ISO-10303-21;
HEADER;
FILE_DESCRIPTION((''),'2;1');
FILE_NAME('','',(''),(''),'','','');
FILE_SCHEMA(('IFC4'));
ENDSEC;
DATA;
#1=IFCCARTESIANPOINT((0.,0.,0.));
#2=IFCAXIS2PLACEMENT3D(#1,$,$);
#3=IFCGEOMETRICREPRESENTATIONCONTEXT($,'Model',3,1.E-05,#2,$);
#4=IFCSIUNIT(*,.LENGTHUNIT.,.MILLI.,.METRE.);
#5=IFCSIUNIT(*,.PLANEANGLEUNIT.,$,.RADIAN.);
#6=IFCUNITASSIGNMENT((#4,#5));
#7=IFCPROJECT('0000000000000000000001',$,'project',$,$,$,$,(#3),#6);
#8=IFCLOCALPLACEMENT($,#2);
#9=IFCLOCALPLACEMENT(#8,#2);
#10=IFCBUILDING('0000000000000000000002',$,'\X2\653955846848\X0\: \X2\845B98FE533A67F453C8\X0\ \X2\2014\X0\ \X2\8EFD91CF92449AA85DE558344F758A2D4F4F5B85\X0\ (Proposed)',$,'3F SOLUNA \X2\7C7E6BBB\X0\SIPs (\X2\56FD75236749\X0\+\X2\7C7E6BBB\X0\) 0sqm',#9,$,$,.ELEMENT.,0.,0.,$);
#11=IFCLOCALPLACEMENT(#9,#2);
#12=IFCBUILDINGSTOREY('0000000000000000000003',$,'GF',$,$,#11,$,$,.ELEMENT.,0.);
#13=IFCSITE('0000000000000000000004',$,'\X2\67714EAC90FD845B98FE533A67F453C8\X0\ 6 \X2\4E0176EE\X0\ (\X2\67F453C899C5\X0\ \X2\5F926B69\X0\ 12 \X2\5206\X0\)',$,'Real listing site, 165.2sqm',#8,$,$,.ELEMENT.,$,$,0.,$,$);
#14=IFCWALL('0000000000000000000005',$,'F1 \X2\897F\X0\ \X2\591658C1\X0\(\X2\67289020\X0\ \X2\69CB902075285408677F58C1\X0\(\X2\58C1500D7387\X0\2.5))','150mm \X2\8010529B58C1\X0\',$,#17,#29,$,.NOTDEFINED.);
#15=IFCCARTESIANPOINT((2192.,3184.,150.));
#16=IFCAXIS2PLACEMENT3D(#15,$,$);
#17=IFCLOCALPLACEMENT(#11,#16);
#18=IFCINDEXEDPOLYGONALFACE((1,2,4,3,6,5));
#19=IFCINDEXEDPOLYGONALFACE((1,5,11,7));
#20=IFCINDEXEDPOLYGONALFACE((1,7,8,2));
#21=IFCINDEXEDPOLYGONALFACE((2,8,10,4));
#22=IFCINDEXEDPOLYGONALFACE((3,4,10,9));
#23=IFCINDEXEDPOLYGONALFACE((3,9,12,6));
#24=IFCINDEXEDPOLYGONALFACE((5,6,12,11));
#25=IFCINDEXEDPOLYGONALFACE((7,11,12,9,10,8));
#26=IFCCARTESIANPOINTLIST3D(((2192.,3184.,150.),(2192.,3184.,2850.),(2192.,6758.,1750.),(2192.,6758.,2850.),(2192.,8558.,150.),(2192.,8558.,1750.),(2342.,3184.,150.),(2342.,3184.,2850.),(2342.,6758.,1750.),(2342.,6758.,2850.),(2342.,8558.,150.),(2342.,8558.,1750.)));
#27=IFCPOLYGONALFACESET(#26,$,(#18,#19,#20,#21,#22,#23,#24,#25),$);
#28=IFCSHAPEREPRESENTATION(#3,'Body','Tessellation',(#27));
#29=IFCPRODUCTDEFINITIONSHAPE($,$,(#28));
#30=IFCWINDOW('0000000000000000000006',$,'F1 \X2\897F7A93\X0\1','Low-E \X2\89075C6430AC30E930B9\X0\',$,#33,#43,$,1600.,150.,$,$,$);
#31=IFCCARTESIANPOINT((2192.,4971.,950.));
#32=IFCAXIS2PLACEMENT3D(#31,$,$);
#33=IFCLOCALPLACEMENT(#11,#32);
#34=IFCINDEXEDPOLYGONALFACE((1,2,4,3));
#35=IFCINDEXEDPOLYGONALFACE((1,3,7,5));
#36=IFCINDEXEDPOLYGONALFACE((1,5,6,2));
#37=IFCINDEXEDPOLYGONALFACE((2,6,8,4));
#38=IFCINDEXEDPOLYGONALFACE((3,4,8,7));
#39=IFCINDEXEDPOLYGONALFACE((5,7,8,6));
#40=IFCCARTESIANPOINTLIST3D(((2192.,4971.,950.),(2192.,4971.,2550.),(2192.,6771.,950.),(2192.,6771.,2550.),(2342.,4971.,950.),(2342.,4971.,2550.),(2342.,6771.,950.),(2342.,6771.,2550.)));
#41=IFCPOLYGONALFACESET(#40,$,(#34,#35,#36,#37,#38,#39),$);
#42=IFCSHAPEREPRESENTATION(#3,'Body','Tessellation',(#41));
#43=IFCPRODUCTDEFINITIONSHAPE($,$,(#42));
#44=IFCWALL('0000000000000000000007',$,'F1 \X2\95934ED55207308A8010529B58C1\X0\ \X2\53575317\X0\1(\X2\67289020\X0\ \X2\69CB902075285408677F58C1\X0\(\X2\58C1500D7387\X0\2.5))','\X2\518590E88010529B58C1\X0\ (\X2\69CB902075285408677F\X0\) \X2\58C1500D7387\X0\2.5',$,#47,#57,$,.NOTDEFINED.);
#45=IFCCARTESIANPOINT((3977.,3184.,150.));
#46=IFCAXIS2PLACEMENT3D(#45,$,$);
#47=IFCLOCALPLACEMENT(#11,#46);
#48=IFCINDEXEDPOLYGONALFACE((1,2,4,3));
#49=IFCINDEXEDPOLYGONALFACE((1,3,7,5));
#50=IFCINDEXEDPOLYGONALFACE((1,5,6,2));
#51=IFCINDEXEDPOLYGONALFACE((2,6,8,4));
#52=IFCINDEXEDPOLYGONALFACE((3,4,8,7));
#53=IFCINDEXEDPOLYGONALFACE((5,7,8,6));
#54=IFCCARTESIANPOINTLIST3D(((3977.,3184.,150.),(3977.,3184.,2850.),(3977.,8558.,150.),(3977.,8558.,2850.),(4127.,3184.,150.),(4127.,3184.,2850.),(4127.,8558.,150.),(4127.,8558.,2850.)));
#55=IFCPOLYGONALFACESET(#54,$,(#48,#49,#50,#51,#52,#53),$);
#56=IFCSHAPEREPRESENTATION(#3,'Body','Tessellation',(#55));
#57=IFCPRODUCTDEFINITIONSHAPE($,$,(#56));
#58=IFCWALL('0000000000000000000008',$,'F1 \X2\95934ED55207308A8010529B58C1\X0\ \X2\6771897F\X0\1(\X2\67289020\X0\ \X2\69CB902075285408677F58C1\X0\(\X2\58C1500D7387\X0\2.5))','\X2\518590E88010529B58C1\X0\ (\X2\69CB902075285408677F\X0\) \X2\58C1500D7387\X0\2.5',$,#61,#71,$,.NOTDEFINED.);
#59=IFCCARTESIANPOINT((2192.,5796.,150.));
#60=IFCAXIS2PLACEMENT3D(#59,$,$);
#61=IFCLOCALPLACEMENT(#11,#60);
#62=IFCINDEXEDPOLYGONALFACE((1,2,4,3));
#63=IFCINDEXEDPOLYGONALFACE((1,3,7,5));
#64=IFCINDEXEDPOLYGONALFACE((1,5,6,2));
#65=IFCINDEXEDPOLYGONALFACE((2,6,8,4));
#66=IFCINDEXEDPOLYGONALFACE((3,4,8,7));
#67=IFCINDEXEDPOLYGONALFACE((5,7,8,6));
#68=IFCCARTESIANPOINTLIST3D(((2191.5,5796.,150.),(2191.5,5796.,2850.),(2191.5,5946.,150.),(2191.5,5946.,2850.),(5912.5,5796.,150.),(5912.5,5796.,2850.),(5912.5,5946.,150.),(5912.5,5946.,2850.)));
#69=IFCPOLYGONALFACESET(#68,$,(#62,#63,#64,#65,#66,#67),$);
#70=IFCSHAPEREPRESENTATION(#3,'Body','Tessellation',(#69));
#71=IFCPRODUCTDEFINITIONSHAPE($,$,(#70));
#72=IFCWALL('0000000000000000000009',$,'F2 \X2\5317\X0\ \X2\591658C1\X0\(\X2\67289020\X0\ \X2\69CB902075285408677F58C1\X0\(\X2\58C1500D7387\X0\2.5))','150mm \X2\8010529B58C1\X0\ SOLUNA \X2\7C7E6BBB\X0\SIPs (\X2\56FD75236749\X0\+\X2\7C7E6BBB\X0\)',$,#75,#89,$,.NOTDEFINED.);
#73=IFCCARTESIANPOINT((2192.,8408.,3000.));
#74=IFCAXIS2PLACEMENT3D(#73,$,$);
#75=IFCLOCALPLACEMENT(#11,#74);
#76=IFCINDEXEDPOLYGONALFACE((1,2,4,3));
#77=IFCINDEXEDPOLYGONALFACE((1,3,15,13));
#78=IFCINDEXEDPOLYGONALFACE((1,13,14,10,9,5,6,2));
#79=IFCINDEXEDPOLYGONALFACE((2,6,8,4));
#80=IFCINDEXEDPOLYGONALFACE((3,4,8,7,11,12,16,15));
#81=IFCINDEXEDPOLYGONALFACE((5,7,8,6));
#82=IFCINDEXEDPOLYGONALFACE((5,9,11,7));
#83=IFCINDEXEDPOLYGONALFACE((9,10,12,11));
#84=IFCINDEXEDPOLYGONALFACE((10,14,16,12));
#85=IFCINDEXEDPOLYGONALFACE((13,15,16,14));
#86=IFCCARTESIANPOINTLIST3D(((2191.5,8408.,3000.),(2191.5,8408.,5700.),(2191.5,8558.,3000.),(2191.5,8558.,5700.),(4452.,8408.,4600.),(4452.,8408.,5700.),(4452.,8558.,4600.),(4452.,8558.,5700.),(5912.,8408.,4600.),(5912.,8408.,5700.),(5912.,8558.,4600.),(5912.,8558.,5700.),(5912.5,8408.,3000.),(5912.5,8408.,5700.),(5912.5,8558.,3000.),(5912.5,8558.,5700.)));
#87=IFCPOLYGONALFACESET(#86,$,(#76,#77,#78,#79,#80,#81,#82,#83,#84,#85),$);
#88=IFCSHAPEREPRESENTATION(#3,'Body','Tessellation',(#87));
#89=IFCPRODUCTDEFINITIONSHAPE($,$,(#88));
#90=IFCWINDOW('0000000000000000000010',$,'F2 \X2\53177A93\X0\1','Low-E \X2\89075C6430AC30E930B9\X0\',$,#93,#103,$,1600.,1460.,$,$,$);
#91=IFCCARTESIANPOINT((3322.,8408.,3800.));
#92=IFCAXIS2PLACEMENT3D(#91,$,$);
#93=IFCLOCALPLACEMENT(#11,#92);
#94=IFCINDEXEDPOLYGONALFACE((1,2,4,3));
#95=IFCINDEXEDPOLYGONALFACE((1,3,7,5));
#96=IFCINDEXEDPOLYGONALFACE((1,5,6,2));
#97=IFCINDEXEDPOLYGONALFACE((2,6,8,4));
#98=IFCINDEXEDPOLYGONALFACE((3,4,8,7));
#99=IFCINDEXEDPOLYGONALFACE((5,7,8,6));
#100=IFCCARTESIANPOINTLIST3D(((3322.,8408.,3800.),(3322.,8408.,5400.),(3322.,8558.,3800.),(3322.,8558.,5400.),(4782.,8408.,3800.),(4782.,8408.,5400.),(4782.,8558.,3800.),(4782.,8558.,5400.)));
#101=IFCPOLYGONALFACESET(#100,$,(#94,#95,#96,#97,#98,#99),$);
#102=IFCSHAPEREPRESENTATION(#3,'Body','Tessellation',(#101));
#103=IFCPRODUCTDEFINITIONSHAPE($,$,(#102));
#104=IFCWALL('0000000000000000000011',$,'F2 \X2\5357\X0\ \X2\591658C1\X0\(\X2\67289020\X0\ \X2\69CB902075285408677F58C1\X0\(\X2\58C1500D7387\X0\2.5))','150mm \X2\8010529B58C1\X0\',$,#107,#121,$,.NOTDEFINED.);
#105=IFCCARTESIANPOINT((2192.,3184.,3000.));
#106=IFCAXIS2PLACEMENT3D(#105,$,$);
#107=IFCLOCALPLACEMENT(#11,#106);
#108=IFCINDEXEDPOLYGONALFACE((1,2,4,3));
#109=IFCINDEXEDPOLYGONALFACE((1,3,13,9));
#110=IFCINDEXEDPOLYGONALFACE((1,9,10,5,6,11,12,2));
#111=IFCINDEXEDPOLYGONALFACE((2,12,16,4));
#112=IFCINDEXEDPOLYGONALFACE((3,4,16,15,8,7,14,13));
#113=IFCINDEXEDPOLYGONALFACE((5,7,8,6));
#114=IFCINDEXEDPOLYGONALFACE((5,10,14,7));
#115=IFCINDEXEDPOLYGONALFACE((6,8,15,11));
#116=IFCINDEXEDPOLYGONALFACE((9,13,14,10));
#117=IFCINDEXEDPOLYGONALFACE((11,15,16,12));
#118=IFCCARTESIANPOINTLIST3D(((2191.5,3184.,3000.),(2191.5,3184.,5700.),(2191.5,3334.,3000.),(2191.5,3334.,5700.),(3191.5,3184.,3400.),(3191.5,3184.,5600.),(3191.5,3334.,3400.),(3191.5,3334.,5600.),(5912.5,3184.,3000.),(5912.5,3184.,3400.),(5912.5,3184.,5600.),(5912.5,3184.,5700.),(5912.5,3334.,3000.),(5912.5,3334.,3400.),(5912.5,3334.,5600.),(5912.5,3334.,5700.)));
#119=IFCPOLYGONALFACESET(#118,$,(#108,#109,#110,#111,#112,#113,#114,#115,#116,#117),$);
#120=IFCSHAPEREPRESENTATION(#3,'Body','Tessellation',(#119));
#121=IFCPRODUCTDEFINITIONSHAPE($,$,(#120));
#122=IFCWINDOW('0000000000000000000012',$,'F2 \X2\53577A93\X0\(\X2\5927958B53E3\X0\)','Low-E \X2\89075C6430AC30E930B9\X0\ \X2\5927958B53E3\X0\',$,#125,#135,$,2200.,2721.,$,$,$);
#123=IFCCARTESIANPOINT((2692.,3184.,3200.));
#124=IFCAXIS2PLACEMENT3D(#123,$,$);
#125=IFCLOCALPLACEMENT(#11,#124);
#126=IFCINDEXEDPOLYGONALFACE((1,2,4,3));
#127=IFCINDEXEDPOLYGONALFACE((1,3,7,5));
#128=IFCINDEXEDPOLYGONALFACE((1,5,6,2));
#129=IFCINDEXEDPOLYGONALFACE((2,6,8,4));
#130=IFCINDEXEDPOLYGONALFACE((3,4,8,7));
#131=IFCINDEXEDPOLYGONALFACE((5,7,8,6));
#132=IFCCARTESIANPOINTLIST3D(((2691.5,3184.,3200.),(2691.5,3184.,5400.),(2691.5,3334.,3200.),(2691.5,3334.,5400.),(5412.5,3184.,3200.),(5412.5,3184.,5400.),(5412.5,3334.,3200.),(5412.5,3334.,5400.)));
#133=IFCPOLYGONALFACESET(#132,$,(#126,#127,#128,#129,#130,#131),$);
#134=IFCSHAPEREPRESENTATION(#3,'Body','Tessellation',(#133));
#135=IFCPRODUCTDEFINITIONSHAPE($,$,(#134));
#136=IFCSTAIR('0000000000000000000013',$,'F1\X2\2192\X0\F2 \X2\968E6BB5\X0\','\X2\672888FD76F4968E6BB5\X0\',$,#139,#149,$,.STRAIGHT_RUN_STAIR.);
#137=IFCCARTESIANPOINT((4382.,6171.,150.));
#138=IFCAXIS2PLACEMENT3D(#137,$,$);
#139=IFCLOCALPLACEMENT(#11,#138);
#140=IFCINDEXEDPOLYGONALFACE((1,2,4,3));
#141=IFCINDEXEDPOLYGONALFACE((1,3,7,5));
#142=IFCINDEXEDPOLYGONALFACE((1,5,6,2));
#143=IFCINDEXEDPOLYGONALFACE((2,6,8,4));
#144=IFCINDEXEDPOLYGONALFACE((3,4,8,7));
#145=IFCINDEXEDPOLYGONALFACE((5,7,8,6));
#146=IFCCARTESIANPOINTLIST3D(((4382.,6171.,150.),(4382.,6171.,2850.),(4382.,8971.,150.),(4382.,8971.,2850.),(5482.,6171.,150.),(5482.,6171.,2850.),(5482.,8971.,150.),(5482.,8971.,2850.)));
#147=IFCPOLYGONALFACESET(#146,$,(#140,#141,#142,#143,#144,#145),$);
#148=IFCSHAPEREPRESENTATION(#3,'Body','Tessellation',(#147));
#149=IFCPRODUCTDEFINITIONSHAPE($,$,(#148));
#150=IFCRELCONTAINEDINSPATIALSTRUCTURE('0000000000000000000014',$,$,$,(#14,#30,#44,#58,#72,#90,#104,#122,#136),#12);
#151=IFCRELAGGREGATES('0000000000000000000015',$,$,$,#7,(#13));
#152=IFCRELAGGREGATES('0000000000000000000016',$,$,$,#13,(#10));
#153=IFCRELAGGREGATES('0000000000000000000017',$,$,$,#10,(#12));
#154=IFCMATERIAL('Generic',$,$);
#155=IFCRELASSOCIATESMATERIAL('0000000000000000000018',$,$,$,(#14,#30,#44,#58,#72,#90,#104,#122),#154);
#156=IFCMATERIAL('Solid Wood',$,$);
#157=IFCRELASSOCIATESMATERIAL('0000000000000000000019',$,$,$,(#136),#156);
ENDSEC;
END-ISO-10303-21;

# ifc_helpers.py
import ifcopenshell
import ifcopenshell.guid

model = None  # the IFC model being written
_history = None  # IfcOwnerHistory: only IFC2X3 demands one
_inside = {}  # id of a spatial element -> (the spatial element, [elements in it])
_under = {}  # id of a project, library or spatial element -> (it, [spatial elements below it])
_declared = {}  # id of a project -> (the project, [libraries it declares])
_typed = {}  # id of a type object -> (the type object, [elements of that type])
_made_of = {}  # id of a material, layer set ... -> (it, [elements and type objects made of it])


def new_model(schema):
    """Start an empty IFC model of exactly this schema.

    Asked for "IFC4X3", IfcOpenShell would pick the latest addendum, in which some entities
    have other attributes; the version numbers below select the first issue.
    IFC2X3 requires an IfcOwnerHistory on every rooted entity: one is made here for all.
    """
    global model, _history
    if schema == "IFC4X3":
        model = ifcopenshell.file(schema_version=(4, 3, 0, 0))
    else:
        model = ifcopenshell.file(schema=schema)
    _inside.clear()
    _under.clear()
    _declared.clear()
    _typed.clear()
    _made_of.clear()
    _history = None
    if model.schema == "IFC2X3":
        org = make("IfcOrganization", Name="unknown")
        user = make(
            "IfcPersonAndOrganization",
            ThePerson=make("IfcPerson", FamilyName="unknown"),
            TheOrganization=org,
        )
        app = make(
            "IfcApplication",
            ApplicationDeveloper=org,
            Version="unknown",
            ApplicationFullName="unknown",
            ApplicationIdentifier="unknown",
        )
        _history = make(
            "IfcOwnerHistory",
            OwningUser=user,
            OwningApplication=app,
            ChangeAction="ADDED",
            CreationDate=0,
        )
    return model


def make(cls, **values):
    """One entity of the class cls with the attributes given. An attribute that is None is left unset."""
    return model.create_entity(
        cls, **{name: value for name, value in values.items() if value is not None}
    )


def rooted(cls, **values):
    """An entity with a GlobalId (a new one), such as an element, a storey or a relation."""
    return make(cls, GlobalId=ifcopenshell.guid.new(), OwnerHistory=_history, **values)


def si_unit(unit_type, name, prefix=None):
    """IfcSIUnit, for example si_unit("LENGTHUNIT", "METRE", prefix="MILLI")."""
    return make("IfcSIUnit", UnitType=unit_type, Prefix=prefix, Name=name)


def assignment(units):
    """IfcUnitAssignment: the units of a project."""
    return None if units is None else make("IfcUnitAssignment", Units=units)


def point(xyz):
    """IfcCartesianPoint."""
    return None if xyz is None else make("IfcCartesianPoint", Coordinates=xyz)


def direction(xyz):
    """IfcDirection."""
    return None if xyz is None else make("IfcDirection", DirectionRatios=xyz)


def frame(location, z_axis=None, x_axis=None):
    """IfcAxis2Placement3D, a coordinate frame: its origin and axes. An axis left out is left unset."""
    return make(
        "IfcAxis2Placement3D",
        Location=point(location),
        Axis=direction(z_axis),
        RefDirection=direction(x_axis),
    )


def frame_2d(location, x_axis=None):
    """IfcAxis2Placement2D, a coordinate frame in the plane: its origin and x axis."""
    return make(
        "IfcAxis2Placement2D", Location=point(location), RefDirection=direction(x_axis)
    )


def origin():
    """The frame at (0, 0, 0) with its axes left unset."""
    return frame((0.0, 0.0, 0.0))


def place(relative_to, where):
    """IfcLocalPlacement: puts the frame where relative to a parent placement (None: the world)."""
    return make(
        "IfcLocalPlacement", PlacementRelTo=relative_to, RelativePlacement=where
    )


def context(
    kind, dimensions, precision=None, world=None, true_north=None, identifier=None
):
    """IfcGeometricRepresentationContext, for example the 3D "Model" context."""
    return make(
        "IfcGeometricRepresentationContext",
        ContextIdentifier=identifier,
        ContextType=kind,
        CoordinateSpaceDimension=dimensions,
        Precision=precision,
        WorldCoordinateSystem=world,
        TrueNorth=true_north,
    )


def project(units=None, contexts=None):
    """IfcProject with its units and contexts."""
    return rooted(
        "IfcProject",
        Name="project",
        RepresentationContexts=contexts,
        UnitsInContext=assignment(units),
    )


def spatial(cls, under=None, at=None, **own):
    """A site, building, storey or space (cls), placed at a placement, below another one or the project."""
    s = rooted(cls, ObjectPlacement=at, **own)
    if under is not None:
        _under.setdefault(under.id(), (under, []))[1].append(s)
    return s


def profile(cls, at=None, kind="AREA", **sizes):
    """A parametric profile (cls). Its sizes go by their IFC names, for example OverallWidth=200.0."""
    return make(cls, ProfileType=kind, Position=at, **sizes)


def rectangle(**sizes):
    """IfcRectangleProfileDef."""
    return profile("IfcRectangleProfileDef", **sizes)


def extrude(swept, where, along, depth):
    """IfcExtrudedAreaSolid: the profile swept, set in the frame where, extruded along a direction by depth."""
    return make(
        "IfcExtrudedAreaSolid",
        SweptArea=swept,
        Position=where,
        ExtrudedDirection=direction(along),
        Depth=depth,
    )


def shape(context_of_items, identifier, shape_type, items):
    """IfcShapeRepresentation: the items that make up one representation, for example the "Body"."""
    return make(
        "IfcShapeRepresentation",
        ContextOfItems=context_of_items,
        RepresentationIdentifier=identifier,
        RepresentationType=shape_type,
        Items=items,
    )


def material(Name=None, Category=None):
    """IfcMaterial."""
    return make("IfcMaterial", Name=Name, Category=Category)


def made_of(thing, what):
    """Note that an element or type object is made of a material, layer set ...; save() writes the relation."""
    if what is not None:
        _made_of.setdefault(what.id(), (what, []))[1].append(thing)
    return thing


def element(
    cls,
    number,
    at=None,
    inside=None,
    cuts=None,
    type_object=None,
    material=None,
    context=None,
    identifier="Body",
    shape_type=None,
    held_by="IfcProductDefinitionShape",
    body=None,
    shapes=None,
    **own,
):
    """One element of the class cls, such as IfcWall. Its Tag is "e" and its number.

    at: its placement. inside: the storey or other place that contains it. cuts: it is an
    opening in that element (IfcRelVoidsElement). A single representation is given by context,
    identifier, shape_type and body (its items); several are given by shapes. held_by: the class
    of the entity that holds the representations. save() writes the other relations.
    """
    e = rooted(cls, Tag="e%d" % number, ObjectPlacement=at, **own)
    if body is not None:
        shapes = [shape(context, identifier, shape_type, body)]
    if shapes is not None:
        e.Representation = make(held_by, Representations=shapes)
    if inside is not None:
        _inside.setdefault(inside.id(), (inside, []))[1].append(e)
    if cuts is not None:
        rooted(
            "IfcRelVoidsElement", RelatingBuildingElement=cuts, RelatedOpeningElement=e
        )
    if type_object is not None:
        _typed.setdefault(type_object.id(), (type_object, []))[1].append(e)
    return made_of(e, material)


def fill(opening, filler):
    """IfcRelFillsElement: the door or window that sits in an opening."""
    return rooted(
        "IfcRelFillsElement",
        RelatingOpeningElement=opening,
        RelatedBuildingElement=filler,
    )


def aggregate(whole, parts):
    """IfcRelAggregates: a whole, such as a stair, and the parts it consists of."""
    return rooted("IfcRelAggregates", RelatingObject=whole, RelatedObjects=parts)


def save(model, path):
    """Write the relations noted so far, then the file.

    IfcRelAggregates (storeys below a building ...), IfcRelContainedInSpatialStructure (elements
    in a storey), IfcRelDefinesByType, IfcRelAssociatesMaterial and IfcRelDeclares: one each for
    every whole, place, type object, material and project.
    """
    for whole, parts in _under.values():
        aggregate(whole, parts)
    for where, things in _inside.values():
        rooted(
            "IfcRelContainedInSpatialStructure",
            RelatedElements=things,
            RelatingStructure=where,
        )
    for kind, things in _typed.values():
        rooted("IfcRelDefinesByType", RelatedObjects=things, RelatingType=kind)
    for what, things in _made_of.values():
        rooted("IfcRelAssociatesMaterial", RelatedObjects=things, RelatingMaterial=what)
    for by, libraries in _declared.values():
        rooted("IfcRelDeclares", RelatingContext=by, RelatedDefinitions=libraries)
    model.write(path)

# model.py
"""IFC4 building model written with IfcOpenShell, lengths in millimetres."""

from ifc_helpers import new_model, si_unit, frame, frame_2d, origin, place, context, project, spatial, rectangle, extrude, material, element, fill, save


model = new_model("IFC4")

# Units and contexts
model_context = context("Model", 3, precision=1e-05, world=origin())
ifc_project = project(units=[si_unit("LENGTHUNIT", "METRE", prefix="MILLI"), si_unit("PLANEANGLEUNIT", "RADIAN")], contexts=[model_context])

# Site, building, storey
site_placement = place(None, origin())
site = spatial("IfcSite", under=ifc_project, at=site_placement, Name="東京都葛飾区柴又 6 丁目 (柴又駅 徒歩 12 分)", ObjectType="Real listing site, 165.2sqm", CompositionType="ELEMENT", RefElevation=0.0)
building_placement = place(site_placement, origin())
building = spatial("IfcBuilding", under=site, at=building_placement, Name="改善案: 葛飾区柴又 — 軽量鉄骨工場併設住宅 (Proposed)", ObjectType="3F SOLUNA 籾殻SIPs (国産杉+籾殻) 0sqm", CompositionType="ELEMENT", ElevationOfRefHeight=0.0, ElevationOfTerrain=0.0)
storey_placement = place(building_placement, origin())
storey = spatial("IfcBuildingStorey", under=building, at=storey_placement, Name="GF", CompositionType="ELEMENT", Elevation=0.0)

# Shared definitions
ifc_material_1 = material(Name="Generic")

# Shared definitions
ifc_material_2 = material(Name="Solid Wood")

# Wall, opening, window
wall_1_placement = place(storey_placement, frame((2192.0, 3184.0, 150.0)))
wall_1 = element("IfcWall", 1, at=wall_1_placement, inside=storey, material=ifc_material_1, Name="F1 西 外壁(木造 構造用合板壁(壁倍率2.5))", Description="150mm 耐力壁", PredefinedType="NOTDEFINED", context=model_context, shape_type="SweptSolid", body=[
    extrude(rectangle(XDim=150.0, YDim=5374.0, at=frame_2d((75.0, 2687.0))), frame((2192.0, 3184.0, 150.0)), (0.0, 0.0, 1.0), 2700.0),
])
opening_1_placement = place(storey_placement, frame((2192.0, 4971.0, 950.0)))
opening_1 = element("IfcOpeningElement", 2, at=opening_1_placement, cuts=wall_1, PredefinedType="NOTDEFINED", context=model_context, shape_type="SweptSolid", body=[
    extrude(rectangle(XDim=150.0, YDim=1800.0, at=frame_2d((75.0, 900.0))), frame((2192.0, 4971.0, 950.0)), (0.0, 0.0, 1.0), 1600.0),
])
window_1_placement = place(storey_placement, frame((2192.0, 4971.0, 950.0)))
window_1 = element("IfcWindow", 3, at=window_1_placement, inside=storey, material=ifc_material_1, Name="F1 西窓1", Description="Low-E 複層ガラス", OverallHeight=1600.0, OverallWidth=150.0, context=model_context, shape_type="SweptSolid", body=[
    extrude(rectangle(XDim=150.0, YDim=1800.0, at=frame_2d((75.0, 900.0))), frame((2192.0, 4971.0, 950.0)), (0.0, 0.0, 1.0), 1600.0),
])
fill(opening_1, window_1)

# Walls
wall_2_placement = place(storey_placement, frame((3977.0, 3184.0, 150.0)))
element("IfcWall", 4, at=wall_2_placement, inside=storey, material=ifc_material_1, Name="F1 間仕切り耐力壁 南北1(木造 構造用合板壁(壁倍率2.5))", Description="内部耐力壁 (構造用合板) 壁倍率2.5", PredefinedType="NOTDEFINED", context=model_context, shape_type="SweptSolid", body=[
    extrude(rectangle(XDim=150.0, YDim=5374.0, at=frame_2d((75.0, 2687.0))), frame((3977.0, 3184.0, 150.0)), (0.0, 0.0, 1.0), 2700.0),
])
wall_3_placement = place(storey_placement, frame((2192.0, 5796.0, 150.0)))
element("IfcWall", 5, at=wall_3_placement, inside=storey, material=ifc_material_1, Name="F1 間仕切り耐力壁 東西1(木造 構造用合板壁(壁倍率2.5))", Description="内部耐力壁 (構造用合板) 壁倍率2.5", PredefinedType="NOTDEFINED", context=model_context, shape_type="SweptSolid", body=[
    extrude(rectangle(XDim=3721.0, YDim=150.0, at=frame_2d((1860.0, 75.0))), frame((2192.0, 5796.0, 150.0)), (0.0, 0.0, 1.0), 2700.0),
])

# Walls, openings, windows
wall_4_placement = place(storey_placement, frame((2192.0, 8408.0, 3000.0)))
wall_4 = element("IfcWall", 6, at=wall_4_placement, inside=storey, material=ifc_material_1, Name="F2 北 外壁(木造 構造用合板壁(壁倍率2.5))", Description="150mm 耐力壁 SOLUNA 籾殻SIPs (国産杉+籾殻)", PredefinedType="NOTDEFINED", context=model_context, shape_type="SweptSolid", body=[
    extrude(rectangle(XDim=3721.0, YDim=150.0, at=frame_2d((1860.0, 75.0))), frame((2192.0, 8408.0, 3000.0)), (0.0, 0.0, 1.0), 2700.0),
])
opening_2_placement = place(storey_placement, frame((3322.0, 8408.0, 3800.0)))
opening_2 = element("IfcOpeningElement", 7, at=opening_2_placement, cuts=wall_4, PredefinedType="NOTDEFINED", context=model_context, shape_type="SweptSolid", body=[
    extrude(rectangle(XDim=1460.0, YDim=150.0, at=frame_2d((730.0, 75.0))), frame((3322.0, 8408.0, 3800.0)), (0.0, 0.0, 1.0), 1600.0),
])
window_2_placement = place(storey_placement, frame((3322.0, 8408.0, 3800.0)))
window_2 = element("IfcWindow", 8, at=window_2_placement, inside=storey, material=ifc_material_1, Name="F2 北窓1", Description="Low-E 複層ガラス", OverallHeight=1600.0, OverallWidth=1460.0, context=model_context, shape_type="SweptSolid", body=[
    extrude(rectangle(XDim=1460.0, YDim=150.0, at=frame_2d((730.0, 75.0))), frame((3322.0, 8408.0, 3800.0)), (0.0, 0.0, 1.0), 1600.0),
])
fill(opening_2, window_2)
wall_5_placement = place(storey_placement, frame((2192.0, 3184.0, 3000.0)))
wall_5 = element("IfcWall", 9, at=wall_5_placement, inside=storey, material=ifc_material_1, Name="F2 南 外壁(木造 構造用合板壁(壁倍率2.5))", Description="150mm 耐力壁", PredefinedType="NOTDEFINED", context=model_context, shape_type="SweptSolid", body=[
    extrude(rectangle(XDim=3721.0, YDim=150.0, at=frame_2d((1860.0, 75.0))), frame((2192.0, 3184.0, 3000.0)), (0.0, 0.0, 1.0), 2700.0),
])
opening_3_placement = place(storey_placement, frame((2692.0, 3184.0, 3200.0)))
opening_3 = element("IfcOpeningElement", 10, at=opening_3_placement, cuts=wall_5, PredefinedType="NOTDEFINED", context=model_context, shape_type="SweptSolid", body=[
    extrude(rectangle(XDim=2721.0, YDim=150.0, at=frame_2d((1360.0, 75.0))), frame((2692.0, 3184.0, 3200.0)), (0.0, 0.0, 1.0), 2200.0),
])
window_3_placement = place(storey_placement, frame((2692.0, 3184.0, 3200.0)))
window_3 = element("IfcWindow", 11, at=window_3_placement, inside=storey, material=ifc_material_1, Name="F2 南窓(大開口)", Description="Low-E 複層ガラス 大開口", OverallHeight=2200.0, OverallWidth=2721.0, context=model_context, shape_type="SweptSolid", body=[
    extrude(rectangle(XDim=2721.0, YDim=150.0, at=frame_2d((1360.0, 75.0))), frame((2692.0, 3184.0, 3200.0)), (0.0, 0.0, 1.0), 2200.0),
])
fill(opening_3, window_3)

# Stair
stair_placement = place(storey_placement, frame((4382.0, 6171.0, 150.0)))
element("IfcStair", 12, at=stair_placement, inside=storey, material=ifc_material_2, Name="F1→F2 階段", Description="木製直階段", PredefinedType="STRAIGHT_RUN_STAIR", context=model_context, shape_type="SweptSolid", body=[
    extrude(rectangle(XDim=1100.0, YDim=2800.0, at=frame_2d((550.0, 1400.0))), frame((4382.0, 6171.0, 150.0)), (0.0, 0.0, 1.0), 2700.0),
])

save(model, "model.ifc")
